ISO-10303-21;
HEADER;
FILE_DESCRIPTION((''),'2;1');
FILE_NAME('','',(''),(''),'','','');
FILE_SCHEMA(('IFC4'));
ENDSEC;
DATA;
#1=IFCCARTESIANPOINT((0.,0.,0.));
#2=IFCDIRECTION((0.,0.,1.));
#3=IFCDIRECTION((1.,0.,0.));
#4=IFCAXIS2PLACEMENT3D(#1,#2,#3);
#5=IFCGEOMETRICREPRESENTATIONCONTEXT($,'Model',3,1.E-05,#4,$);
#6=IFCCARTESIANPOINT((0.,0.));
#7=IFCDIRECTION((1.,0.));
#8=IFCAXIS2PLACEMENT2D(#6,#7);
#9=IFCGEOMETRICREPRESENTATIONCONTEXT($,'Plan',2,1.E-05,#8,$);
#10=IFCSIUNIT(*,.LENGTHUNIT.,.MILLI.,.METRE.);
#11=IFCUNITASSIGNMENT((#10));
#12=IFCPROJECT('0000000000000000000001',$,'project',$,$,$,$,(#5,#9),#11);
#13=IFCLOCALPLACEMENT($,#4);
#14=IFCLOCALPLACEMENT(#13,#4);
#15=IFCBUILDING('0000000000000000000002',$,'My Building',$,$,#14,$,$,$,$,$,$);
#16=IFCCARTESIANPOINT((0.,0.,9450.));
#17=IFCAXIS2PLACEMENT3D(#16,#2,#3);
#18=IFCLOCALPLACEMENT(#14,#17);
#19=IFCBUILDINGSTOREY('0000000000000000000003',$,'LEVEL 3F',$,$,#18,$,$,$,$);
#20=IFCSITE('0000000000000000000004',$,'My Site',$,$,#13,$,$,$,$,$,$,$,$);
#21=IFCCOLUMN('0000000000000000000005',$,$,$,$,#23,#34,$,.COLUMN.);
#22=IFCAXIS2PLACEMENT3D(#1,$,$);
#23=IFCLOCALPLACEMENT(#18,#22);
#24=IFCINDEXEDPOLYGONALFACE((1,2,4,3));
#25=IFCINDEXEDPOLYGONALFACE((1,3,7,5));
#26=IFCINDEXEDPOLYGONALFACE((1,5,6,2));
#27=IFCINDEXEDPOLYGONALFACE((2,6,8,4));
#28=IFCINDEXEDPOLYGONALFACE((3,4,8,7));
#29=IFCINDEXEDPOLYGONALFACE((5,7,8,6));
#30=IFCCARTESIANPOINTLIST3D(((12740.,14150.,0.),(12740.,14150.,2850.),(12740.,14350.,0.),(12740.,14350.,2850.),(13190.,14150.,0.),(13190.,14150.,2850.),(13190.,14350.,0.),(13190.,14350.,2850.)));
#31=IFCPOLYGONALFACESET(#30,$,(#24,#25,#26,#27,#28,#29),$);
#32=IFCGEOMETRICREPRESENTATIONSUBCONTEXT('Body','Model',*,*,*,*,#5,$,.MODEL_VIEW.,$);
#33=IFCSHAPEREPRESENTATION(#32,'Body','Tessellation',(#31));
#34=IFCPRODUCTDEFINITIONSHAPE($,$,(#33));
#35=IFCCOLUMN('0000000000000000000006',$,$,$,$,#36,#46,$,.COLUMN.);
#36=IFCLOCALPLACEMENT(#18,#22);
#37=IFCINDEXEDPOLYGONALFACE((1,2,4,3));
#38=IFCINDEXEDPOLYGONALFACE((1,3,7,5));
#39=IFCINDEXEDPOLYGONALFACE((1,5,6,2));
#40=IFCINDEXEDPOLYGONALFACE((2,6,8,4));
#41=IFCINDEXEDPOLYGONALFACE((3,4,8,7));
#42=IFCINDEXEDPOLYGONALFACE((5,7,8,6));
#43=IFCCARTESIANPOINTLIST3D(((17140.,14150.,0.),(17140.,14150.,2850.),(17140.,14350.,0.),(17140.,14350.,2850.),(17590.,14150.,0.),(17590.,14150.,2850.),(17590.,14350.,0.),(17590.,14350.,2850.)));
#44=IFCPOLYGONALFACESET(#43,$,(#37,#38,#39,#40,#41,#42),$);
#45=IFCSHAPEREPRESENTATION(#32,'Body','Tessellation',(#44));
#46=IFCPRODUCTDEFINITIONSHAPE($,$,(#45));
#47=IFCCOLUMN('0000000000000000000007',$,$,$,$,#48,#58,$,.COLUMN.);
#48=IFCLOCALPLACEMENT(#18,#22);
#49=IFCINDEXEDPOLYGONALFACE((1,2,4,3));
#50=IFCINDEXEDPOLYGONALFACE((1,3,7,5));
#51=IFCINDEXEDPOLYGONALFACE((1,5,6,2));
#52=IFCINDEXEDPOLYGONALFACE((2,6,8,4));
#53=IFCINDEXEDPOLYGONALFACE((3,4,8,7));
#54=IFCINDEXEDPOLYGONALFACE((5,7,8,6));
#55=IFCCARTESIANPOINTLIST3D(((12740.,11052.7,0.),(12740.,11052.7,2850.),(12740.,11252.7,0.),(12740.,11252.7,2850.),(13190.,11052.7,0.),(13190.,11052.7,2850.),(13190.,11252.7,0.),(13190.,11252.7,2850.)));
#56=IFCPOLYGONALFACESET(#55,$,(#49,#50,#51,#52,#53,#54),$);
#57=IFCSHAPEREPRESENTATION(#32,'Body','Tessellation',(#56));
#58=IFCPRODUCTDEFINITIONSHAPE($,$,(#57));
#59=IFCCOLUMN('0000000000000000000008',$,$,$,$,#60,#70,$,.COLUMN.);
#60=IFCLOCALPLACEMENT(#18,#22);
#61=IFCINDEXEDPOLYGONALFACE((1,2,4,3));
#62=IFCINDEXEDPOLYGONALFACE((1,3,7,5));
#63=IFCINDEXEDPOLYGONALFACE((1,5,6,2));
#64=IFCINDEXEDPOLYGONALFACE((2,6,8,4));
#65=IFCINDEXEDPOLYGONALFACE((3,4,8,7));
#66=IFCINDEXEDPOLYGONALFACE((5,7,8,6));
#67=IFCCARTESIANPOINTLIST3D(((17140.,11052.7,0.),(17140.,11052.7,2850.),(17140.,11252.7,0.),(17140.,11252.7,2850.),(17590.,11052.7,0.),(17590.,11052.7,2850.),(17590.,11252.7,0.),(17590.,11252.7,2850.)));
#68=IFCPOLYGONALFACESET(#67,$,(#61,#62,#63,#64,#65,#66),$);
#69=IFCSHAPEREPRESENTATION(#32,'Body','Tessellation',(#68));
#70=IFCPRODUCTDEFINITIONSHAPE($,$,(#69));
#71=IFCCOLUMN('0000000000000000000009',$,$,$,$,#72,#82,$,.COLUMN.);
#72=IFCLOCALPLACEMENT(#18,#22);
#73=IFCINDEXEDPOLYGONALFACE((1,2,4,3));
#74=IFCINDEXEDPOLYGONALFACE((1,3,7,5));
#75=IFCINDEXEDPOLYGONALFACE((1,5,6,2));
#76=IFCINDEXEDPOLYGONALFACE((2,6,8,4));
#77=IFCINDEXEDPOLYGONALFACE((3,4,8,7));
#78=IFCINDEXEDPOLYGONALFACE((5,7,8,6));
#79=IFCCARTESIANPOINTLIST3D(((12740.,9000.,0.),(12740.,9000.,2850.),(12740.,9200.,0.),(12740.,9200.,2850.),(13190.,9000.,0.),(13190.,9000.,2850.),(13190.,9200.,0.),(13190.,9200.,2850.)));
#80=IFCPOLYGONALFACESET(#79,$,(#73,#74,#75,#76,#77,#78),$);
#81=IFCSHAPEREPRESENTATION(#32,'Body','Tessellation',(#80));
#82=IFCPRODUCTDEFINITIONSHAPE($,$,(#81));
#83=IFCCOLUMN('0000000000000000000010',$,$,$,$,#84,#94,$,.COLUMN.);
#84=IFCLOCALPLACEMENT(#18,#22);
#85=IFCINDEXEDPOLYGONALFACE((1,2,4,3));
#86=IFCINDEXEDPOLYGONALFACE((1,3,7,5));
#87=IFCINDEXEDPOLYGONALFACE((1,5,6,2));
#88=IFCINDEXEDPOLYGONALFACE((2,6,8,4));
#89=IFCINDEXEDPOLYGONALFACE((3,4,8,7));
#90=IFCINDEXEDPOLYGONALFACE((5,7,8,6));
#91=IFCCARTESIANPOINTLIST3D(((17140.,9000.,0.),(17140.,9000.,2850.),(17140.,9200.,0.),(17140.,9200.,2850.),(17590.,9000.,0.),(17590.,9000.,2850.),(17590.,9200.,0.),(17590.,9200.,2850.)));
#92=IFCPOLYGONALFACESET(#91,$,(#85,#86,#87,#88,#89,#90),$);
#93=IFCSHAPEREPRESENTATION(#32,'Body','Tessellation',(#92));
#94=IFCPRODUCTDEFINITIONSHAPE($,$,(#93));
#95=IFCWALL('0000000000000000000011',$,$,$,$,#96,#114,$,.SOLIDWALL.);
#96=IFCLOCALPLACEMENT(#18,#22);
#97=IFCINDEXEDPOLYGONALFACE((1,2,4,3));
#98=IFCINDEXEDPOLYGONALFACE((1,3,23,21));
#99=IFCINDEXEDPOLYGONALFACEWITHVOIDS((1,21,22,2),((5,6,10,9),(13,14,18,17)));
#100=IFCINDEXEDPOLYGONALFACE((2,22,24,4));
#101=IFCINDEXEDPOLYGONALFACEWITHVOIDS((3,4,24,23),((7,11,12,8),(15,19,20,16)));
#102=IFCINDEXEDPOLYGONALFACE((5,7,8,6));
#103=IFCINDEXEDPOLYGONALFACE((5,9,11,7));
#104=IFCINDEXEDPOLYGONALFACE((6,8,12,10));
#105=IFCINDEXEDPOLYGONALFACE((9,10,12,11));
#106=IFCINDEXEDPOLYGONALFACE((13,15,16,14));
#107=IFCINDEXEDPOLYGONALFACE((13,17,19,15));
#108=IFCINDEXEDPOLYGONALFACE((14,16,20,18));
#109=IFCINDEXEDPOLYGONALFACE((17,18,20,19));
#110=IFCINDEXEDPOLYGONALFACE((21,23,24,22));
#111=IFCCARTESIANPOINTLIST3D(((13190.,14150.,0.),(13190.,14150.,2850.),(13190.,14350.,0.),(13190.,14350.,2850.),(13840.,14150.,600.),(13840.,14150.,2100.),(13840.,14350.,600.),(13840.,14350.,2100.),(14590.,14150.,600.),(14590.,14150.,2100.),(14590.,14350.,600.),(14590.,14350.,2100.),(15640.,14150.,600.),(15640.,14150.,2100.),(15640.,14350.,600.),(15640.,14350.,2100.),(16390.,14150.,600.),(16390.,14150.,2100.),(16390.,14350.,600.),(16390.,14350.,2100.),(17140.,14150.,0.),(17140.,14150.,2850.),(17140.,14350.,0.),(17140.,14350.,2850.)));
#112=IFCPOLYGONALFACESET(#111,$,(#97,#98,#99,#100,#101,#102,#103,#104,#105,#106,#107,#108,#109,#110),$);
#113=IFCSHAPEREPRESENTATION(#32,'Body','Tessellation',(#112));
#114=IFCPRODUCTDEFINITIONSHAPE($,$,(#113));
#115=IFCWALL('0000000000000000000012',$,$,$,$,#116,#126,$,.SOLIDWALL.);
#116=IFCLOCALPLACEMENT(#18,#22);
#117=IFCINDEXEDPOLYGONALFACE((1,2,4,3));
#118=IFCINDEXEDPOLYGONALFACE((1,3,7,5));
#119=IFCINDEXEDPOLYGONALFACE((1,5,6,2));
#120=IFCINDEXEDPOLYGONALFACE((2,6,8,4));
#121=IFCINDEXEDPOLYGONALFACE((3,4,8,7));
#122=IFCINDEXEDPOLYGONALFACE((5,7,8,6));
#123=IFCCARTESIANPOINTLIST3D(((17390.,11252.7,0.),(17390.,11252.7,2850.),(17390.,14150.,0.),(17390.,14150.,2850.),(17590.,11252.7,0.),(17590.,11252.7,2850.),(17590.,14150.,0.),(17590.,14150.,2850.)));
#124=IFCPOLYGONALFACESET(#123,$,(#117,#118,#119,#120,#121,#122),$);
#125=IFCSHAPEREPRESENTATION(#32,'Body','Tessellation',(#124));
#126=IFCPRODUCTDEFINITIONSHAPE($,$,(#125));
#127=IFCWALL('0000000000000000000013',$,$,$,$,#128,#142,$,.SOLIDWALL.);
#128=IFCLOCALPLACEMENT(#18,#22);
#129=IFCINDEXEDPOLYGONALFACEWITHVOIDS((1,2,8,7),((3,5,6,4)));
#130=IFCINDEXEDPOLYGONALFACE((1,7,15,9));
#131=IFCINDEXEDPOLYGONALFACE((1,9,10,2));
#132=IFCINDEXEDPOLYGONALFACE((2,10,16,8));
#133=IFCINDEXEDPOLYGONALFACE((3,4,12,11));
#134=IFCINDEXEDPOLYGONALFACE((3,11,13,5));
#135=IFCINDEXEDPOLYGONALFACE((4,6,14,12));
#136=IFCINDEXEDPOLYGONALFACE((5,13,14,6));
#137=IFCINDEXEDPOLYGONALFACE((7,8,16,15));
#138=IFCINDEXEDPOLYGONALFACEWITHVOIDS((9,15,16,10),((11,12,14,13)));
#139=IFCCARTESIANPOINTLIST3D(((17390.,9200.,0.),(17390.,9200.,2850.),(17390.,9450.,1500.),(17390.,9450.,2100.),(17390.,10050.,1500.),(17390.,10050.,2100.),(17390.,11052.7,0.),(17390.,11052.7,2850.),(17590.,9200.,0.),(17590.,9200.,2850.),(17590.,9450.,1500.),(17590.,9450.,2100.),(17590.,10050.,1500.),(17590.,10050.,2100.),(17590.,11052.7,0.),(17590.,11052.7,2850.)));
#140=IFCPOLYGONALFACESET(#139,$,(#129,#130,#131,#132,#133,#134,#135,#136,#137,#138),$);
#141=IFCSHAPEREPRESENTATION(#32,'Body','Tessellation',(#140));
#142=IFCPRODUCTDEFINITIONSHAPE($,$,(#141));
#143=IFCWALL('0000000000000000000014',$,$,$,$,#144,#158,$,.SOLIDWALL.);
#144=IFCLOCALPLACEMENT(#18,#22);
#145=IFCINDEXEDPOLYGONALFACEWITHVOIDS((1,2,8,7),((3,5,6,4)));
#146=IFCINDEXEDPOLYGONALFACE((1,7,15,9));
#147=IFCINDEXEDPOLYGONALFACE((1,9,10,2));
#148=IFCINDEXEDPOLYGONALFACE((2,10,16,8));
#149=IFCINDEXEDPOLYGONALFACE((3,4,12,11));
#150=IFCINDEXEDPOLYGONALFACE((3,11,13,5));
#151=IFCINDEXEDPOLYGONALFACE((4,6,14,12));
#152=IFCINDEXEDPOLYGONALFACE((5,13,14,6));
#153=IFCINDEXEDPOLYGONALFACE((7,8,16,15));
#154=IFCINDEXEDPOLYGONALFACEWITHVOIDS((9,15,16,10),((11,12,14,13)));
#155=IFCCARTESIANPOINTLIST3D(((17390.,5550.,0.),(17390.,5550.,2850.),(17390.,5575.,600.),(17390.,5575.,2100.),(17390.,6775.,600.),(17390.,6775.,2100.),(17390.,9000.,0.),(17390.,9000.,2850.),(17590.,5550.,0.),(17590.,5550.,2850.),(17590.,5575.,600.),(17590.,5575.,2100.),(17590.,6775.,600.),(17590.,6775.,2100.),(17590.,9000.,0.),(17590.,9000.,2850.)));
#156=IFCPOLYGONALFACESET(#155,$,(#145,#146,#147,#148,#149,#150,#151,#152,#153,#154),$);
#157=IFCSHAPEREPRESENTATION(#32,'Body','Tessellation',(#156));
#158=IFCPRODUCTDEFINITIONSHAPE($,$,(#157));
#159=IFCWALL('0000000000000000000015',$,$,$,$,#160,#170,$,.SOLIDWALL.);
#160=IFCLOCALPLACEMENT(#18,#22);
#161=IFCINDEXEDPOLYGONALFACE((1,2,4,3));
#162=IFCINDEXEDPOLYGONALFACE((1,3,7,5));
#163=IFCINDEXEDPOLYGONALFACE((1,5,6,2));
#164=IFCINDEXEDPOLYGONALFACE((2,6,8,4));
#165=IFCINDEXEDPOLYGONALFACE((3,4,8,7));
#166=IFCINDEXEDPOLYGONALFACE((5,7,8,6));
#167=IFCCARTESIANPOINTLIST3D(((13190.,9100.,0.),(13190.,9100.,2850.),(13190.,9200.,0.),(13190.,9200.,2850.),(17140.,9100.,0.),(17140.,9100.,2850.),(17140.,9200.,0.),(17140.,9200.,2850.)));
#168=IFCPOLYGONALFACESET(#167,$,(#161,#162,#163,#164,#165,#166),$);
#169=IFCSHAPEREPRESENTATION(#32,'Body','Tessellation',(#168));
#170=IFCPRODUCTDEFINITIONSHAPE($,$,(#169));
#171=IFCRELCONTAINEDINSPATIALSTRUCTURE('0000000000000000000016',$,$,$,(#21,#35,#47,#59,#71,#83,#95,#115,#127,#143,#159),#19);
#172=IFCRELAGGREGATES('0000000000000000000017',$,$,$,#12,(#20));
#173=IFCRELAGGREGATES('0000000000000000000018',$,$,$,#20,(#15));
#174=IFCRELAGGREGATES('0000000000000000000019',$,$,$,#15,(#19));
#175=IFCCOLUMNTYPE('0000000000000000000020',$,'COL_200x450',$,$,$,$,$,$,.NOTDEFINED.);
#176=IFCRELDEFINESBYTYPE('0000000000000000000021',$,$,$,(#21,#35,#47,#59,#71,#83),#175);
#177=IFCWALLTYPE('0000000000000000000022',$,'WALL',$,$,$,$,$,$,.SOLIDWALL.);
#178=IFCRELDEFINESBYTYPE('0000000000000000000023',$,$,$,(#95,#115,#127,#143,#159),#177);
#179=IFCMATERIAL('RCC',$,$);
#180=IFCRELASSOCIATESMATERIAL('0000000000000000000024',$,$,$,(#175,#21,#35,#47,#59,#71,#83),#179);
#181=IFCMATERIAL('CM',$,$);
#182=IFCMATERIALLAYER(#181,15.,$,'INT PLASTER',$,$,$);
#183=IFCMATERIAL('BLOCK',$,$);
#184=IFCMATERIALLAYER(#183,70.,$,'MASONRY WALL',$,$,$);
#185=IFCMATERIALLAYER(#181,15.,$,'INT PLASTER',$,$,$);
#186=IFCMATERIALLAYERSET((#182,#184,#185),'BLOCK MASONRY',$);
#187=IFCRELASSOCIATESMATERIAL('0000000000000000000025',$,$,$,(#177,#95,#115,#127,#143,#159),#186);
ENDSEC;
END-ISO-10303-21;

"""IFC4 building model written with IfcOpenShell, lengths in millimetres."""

from ifc_helpers import new_model, si_unit, frame, origin_with_axes, origin_2d_with_axis, place, context, subcontext, project, spatial, indexed_curve, rectangle, outline, extrude, material, layer, layer_set, layer_usage, material_profile, profile_set, profile_usage, type_object, element, save


model = new_model("IFC4")

# Units and contexts
model_context = context("Model", 3, precision=1e-05, world=origin_with_axes())
plan_context = context("Plan", 2, precision=1e-05, world=origin_2d_with_axis())
body_context = subcontext(model_context, "Body", "Model", "MODEL_VIEW")
ifc_project = project(units=[si_unit("LENGTHUNIT", "METRE", prefix="MILLI")], contexts=[model_context, plan_context])

# Site, building, storey
site_placement = place(None, origin_with_axes())
site = spatial("IfcSite", under=ifc_project, at=site_placement, Name="My Site")
building_placement = place(site_placement, origin_with_axes())
building = spatial("IfcBuilding", under=site, at=building_placement, Name="My Building")
storey_placement = place(building_placement, frame((0.0, 0.0, 9450.0), z_axis=(0.0, 0.0, 1.0), x_axis=(1.0, 0.0, 0.0)))
storey = spatial("IfcBuildingStorey", under=building, at=storey_placement, Name="LEVEL 3F")

# Columns
ifc_material_1 = material(Name="RCC")
ifc_material_profile = material_profile(ifc_material_1, rectangle(XDim=200.0, YDim=450.0))
ifc_profile_set = profile_set([ifc_material_profile], Name="COL_200x450")
ifc_profile_usage_1 = profile_usage(ifc_profile_set)
column_type = type_object("IfcColumnType", Name="COL_200x450", PredefinedType="NOTDEFINED", material=ifc_profile_set)
column_1_placement = place(storey_placement, frame((12965.0, 14250.0, 0.0), z_axis=(0.0, 0.0, 1.0), x_axis=(0.0, -1.0, 0.0)))
element("IfcColumn", 1, at=column_1_placement, inside=storey, type_object=column_type, material=ifc_profile_usage_1, PredefinedType="COLUMN", context=body_context, shape_type="SweptSolid", body=[
    extrude(rectangle(XDim=200.0, YDim=450.0), origin_with_axes(), (0.0, 0.0, 1.0), 2850.0),
])
ifc_profile_usage_2 = profile_usage(ifc_profile_set)
column_2_placement = place(storey_placement, frame((17365.0, 14250.0, 0.0), z_axis=(0.0, 0.0, 1.0), x_axis=(0.0, -1.0, 0.0)))
element("IfcColumn", 2, at=column_2_placement, inside=storey, type_object=column_type, material=ifc_profile_usage_2, PredefinedType="COLUMN", context=body_context, shape_type="SweptSolid", body=[
    extrude(rectangle(XDim=200.0, YDim=450.0), origin_with_axes(), (0.0, 0.0, 1.0), 2850.0),
])
ifc_profile_usage_3 = profile_usage(ifc_profile_set)
column_3_placement = place(storey_placement, frame((12965.0, 11152.7, 0.0), z_axis=(0.0, 0.0, 1.0), x_axis=(0.0, -1.0, 0.0)))
element("IfcColumn", 3, at=column_3_placement, inside=storey, type_object=column_type, material=ifc_profile_usage_3, PredefinedType="COLUMN", context=body_context, shape_type="SweptSolid", body=[
    extrude(rectangle(XDim=200.0, YDim=450.0), origin_with_axes(), (0.0, 0.0, 1.0), 2850.0),
])
ifc_profile_usage_4 = profile_usage(ifc_profile_set)
column_4_placement = place(storey_placement, frame((17365.0, 11152.7, 0.0), z_axis=(0.0, 0.0, 1.0), x_axis=(0.0, -1.0, 0.0)))
element("IfcColumn", 4, at=column_4_placement, inside=storey, type_object=column_type, material=ifc_profile_usage_4, PredefinedType="COLUMN", context=body_context, shape_type="SweptSolid", body=[
    extrude(rectangle(XDim=200.0, YDim=450.0), origin_with_axes(), (0.0, 0.0, 1.0), 2850.0),
])
ifc_profile_usage_5 = profile_usage(ifc_profile_set)
column_5_placement = place(storey_placement, frame((12965.0, 9100.0, 0.0), z_axis=(0.0, 0.0, 1.0), x_axis=(0.0, -1.0, 0.0)))
element("IfcColumn", 5, at=column_5_placement, inside=storey, type_object=column_type, material=ifc_profile_usage_5, PredefinedType="COLUMN", context=body_context, shape_type="SweptSolid", body=[
    extrude(rectangle(XDim=200.0, YDim=450.0), origin_with_axes(), (0.0, 0.0, 1.0), 2850.0),
])
ifc_profile_usage_6 = profile_usage(ifc_profile_set)
column_6_placement = place(storey_placement, frame((17365.0, 9100.0, 0.0), z_axis=(0.0, 0.0, 1.0), x_axis=(0.0, -1.0, 0.0)))
element("IfcColumn", 6, at=column_6_placement, inside=storey, type_object=column_type, material=ifc_profile_usage_6, PredefinedType="COLUMN", context=body_context, shape_type="SweptSolid", body=[
    extrude(rectangle(XDim=200.0, YDim=450.0), origin_with_axes(), (0.0, 0.0, 1.0), 2850.0),
])

# Wall, openings
ifc_material_2 = material(Name="CM")
ifc_layer_1 = layer(ifc_material_2, 15.0, Name="INT PLASTER")
ifc_material_3 = material(Name="BLOCK")
ifc_layer_2 = layer(ifc_material_3, 70.0, Name="MASONRY WALL")
ifc_layer_3 = layer(ifc_material_2, 15.0, Name="INT PLASTER")
ifc_layer_set = layer_set([ifc_layer_1, ifc_layer_2, ifc_layer_3], Name="BLOCK MASONRY")
ifc_layer_usage_1 = layer_usage(ifc_layer_set, "AXIS2", "POSITIVE", 0.0)
wall_type = type_object("IfcWallType", Name="WALL", PredefinedType="SOLIDWALL", material=ifc_layer_set)
wall_1_placement = place(storey_placement, frame((13190.0, 14350.0, 0.0), z_axis=(0.0, 0.0, 1.0), x_axis=(0.0, -1.0, 0.0)))
wall_1 = element("IfcWall", 7, at=wall_1_placement, inside=storey, type_object=wall_type, material=ifc_layer_usage_1, PredefinedType="SOLIDWALL", context=body_context, shape_type="SweptSolid", body=[
    extrude(outline(indexed_curve([(0.0, 0.0), (0.0, 3950.0), (200.0, 3950.0), (200.0, 0.0), (0.0, 0.0)], self_intersect=False)), origin_with_axes(), (0.0, 0.0, 1.0), 2850.0),
])
opening_1_placement = place(wall_1_placement, frame((200.0, 650.0, 600.0), z_axis=(0.0, 0.0, 1.0), x_axis=(0.0, 1.0, 0.0)))
element("IfcOpeningElement", 8, at=opening_1_placement, cuts=wall_1, PredefinedType="OPENING", context=body_context, shape_type="SweptSolid", body=[
    extrude(outline(indexed_curve([(0.0, 0.0), (0.0, 400.0), (750.0, 400.0), (750.0, 0.0), (0.0, 0.0)], self_intersect=False)), frame((0.0, -100.0, 0.0), z_axis=(0.0, 0.0, 1.0), x_axis=(1.0, 0.0, 0.0)), (0.0, 0.0, 1.0), 1500.0),
])
opening_2_placement = place(wall_1_placement, frame((200.0, 2450.0, 600.0), z_axis=(0.0, 0.0, 1.0), x_axis=(0.0, 1.0, 0.0)))
element("IfcOpeningElement", 9, at=opening_2_placement, cuts=wall_1, PredefinedType="OPENING", context=body_context, shape_type="SweptSolid", body=[
    extrude(outline(indexed_curve([(0.0, 0.0), (0.0, 400.0), (750.0, 400.0), (750.0, 0.0), (0.0, 0.0)], self_intersect=False)), frame((0.0, -100.0, 0.0), z_axis=(0.0, 0.0, 1.0), x_axis=(1.0, 0.0, 0.0)), (0.0, 0.0, 1.0), 1500.0),
])

# Wall
ifc_layer_usage_2 = layer_usage(ifc_layer_set, "AXIS2", "POSITIVE", 0.0)
wall_2_placement = place(storey_placement, frame((17590.0, 11252.7, 0.0), z_axis=(0.0, 0.0, 1.0), x_axis=(0.0, 1.0, 0.0)))
element("IfcWall", 10, at=wall_2_placement, inside=storey, type_object=wall_type, material=ifc_layer_usage_2, PredefinedType="SOLIDWALL", context=body_context, shape_type="SweptSolid", body=[
    extrude(outline(indexed_curve([(0.0, 0.0), (0.0, 200.0), (2897.3, 200.0), (2897.3, 0.0), (0.0, 0.0)], self_intersect=False)), origin_with_axes(), (0.0, 0.0, 1.0), 2850.0),
])

# Walls, openings
ifc_layer_usage_3 = layer_usage(ifc_layer_set, "AXIS2", "POSITIVE", 0.0)
wall_3_placement = place(storey_placement, frame((17590.0, 9200.0, 0.0), z_axis=(0.0, 0.0, 1.0), x_axis=(0.0, 1.0, 0.0)))
wall_3 = element("IfcWall", 11, at=wall_3_placement, inside=storey, type_object=wall_type, material=ifc_layer_usage_3, PredefinedType="SOLIDWALL", context=body_context, shape_type="SweptSolid", body=[
    extrude(outline(indexed_curve([(0.0, 0.0), (0.0, 200.0), (1852.7, 200.0), (1852.7, 0.0), (0.0, 0.0)], self_intersect=False)), origin_with_axes(), (0.0, 0.0, 1.0), 2850.0),
])
opening_3_placement = place(wall_3_placement, frame((850.0, 200.0, 1500.0), z_axis=(0.0, 0.0, 1.0), x_axis=(-1.0, 0.0, 0.0)))
element("IfcOpeningElement", 12, at=opening_3_placement, cuts=wall_3, PredefinedType="OPENING", context=body_context, shape_type="SweptSolid", body=[
    extrude(outline(indexed_curve([(0.0, 0.0), (0.0, 400.0), (600.0, 400.0), (600.0, 0.0), (0.0, 0.0)], self_intersect=False)), frame((0.0, -100.0, 0.0), z_axis=(0.0, 0.0, 1.0), x_axis=(1.0, 0.0, 0.0)), (0.0, 0.0, 1.0), 600.0),
])
ifc_layer_usage_4 = layer_usage(ifc_layer_set, "AXIS2", "POSITIVE", 0.0)
wall_4_placement = place(storey_placement, frame((17590.0, 5550.0, 0.0), z_axis=(0.0, 0.0, 1.0), x_axis=(0.0, 1.0, 0.0)))
wall_4 = element("IfcWall", 13, at=wall_4_placement, inside=storey, type_object=wall_type, material=ifc_layer_usage_4, PredefinedType="SOLIDWALL", context=body_context, shape_type="SweptSolid", body=[
    extrude(outline(indexed_curve([(0.0, 0.0), (0.0, 200.0), (3450.0, 200.0), (3450.0, 0.0), (0.0, 0.0)], self_intersect=False)), origin_with_axes(), (0.0, 0.0, 1.0), 2850.0),
])
opening_4_placement = place(wall_4_placement, frame((1225.0, 200.0, 600.0), z_axis=(0.0, 0.0, 1.0), x_axis=(-1.0, 0.0, 0.0)))
element("IfcOpeningElement", 14, at=opening_4_placement, cuts=wall_4, PredefinedType="OPENING", context=body_context, shape_type="SweptSolid", body=[
    extrude(outline(indexed_curve([(0.0, 0.0), (0.0, 400.0), (1200.0, 400.0), (1200.0, 0.0), (0.0, 0.0)], self_intersect=False)), frame((0.0, -100.0, 0.0), z_axis=(0.0, 0.0, 1.0), x_axis=(1.0, 0.0, 0.0)), (0.0, 0.0, 1.0), 1500.0),
])

# Wall
ifc_layer_usage_5 = layer_usage(ifc_layer_set, "AXIS2", "POSITIVE", 0.0)
wall_5_placement = place(storey_placement, frame((13190.0, 9200.0, 0.0), z_axis=(0.0, 0.0, 1.0), x_axis=(0.0, -1.0, 0.0)))
element("IfcWall", 15, at=wall_5_placement, inside=storey, type_object=wall_type, material=ifc_layer_usage_5, PredefinedType="SOLIDWALL", context=body_context, shape_type="SweptSolid", body=[
    extrude(outline(indexed_curve([(0.0, 0.0), (0.0, 3950.0), (100.0, 3950.0), (100.0, 0.0), (0.0, 0.0)], self_intersect=False)), origin_with_axes(), (0.0, 0.0, 1.0), 2850.0),
])

save(model, "model.ifc")
